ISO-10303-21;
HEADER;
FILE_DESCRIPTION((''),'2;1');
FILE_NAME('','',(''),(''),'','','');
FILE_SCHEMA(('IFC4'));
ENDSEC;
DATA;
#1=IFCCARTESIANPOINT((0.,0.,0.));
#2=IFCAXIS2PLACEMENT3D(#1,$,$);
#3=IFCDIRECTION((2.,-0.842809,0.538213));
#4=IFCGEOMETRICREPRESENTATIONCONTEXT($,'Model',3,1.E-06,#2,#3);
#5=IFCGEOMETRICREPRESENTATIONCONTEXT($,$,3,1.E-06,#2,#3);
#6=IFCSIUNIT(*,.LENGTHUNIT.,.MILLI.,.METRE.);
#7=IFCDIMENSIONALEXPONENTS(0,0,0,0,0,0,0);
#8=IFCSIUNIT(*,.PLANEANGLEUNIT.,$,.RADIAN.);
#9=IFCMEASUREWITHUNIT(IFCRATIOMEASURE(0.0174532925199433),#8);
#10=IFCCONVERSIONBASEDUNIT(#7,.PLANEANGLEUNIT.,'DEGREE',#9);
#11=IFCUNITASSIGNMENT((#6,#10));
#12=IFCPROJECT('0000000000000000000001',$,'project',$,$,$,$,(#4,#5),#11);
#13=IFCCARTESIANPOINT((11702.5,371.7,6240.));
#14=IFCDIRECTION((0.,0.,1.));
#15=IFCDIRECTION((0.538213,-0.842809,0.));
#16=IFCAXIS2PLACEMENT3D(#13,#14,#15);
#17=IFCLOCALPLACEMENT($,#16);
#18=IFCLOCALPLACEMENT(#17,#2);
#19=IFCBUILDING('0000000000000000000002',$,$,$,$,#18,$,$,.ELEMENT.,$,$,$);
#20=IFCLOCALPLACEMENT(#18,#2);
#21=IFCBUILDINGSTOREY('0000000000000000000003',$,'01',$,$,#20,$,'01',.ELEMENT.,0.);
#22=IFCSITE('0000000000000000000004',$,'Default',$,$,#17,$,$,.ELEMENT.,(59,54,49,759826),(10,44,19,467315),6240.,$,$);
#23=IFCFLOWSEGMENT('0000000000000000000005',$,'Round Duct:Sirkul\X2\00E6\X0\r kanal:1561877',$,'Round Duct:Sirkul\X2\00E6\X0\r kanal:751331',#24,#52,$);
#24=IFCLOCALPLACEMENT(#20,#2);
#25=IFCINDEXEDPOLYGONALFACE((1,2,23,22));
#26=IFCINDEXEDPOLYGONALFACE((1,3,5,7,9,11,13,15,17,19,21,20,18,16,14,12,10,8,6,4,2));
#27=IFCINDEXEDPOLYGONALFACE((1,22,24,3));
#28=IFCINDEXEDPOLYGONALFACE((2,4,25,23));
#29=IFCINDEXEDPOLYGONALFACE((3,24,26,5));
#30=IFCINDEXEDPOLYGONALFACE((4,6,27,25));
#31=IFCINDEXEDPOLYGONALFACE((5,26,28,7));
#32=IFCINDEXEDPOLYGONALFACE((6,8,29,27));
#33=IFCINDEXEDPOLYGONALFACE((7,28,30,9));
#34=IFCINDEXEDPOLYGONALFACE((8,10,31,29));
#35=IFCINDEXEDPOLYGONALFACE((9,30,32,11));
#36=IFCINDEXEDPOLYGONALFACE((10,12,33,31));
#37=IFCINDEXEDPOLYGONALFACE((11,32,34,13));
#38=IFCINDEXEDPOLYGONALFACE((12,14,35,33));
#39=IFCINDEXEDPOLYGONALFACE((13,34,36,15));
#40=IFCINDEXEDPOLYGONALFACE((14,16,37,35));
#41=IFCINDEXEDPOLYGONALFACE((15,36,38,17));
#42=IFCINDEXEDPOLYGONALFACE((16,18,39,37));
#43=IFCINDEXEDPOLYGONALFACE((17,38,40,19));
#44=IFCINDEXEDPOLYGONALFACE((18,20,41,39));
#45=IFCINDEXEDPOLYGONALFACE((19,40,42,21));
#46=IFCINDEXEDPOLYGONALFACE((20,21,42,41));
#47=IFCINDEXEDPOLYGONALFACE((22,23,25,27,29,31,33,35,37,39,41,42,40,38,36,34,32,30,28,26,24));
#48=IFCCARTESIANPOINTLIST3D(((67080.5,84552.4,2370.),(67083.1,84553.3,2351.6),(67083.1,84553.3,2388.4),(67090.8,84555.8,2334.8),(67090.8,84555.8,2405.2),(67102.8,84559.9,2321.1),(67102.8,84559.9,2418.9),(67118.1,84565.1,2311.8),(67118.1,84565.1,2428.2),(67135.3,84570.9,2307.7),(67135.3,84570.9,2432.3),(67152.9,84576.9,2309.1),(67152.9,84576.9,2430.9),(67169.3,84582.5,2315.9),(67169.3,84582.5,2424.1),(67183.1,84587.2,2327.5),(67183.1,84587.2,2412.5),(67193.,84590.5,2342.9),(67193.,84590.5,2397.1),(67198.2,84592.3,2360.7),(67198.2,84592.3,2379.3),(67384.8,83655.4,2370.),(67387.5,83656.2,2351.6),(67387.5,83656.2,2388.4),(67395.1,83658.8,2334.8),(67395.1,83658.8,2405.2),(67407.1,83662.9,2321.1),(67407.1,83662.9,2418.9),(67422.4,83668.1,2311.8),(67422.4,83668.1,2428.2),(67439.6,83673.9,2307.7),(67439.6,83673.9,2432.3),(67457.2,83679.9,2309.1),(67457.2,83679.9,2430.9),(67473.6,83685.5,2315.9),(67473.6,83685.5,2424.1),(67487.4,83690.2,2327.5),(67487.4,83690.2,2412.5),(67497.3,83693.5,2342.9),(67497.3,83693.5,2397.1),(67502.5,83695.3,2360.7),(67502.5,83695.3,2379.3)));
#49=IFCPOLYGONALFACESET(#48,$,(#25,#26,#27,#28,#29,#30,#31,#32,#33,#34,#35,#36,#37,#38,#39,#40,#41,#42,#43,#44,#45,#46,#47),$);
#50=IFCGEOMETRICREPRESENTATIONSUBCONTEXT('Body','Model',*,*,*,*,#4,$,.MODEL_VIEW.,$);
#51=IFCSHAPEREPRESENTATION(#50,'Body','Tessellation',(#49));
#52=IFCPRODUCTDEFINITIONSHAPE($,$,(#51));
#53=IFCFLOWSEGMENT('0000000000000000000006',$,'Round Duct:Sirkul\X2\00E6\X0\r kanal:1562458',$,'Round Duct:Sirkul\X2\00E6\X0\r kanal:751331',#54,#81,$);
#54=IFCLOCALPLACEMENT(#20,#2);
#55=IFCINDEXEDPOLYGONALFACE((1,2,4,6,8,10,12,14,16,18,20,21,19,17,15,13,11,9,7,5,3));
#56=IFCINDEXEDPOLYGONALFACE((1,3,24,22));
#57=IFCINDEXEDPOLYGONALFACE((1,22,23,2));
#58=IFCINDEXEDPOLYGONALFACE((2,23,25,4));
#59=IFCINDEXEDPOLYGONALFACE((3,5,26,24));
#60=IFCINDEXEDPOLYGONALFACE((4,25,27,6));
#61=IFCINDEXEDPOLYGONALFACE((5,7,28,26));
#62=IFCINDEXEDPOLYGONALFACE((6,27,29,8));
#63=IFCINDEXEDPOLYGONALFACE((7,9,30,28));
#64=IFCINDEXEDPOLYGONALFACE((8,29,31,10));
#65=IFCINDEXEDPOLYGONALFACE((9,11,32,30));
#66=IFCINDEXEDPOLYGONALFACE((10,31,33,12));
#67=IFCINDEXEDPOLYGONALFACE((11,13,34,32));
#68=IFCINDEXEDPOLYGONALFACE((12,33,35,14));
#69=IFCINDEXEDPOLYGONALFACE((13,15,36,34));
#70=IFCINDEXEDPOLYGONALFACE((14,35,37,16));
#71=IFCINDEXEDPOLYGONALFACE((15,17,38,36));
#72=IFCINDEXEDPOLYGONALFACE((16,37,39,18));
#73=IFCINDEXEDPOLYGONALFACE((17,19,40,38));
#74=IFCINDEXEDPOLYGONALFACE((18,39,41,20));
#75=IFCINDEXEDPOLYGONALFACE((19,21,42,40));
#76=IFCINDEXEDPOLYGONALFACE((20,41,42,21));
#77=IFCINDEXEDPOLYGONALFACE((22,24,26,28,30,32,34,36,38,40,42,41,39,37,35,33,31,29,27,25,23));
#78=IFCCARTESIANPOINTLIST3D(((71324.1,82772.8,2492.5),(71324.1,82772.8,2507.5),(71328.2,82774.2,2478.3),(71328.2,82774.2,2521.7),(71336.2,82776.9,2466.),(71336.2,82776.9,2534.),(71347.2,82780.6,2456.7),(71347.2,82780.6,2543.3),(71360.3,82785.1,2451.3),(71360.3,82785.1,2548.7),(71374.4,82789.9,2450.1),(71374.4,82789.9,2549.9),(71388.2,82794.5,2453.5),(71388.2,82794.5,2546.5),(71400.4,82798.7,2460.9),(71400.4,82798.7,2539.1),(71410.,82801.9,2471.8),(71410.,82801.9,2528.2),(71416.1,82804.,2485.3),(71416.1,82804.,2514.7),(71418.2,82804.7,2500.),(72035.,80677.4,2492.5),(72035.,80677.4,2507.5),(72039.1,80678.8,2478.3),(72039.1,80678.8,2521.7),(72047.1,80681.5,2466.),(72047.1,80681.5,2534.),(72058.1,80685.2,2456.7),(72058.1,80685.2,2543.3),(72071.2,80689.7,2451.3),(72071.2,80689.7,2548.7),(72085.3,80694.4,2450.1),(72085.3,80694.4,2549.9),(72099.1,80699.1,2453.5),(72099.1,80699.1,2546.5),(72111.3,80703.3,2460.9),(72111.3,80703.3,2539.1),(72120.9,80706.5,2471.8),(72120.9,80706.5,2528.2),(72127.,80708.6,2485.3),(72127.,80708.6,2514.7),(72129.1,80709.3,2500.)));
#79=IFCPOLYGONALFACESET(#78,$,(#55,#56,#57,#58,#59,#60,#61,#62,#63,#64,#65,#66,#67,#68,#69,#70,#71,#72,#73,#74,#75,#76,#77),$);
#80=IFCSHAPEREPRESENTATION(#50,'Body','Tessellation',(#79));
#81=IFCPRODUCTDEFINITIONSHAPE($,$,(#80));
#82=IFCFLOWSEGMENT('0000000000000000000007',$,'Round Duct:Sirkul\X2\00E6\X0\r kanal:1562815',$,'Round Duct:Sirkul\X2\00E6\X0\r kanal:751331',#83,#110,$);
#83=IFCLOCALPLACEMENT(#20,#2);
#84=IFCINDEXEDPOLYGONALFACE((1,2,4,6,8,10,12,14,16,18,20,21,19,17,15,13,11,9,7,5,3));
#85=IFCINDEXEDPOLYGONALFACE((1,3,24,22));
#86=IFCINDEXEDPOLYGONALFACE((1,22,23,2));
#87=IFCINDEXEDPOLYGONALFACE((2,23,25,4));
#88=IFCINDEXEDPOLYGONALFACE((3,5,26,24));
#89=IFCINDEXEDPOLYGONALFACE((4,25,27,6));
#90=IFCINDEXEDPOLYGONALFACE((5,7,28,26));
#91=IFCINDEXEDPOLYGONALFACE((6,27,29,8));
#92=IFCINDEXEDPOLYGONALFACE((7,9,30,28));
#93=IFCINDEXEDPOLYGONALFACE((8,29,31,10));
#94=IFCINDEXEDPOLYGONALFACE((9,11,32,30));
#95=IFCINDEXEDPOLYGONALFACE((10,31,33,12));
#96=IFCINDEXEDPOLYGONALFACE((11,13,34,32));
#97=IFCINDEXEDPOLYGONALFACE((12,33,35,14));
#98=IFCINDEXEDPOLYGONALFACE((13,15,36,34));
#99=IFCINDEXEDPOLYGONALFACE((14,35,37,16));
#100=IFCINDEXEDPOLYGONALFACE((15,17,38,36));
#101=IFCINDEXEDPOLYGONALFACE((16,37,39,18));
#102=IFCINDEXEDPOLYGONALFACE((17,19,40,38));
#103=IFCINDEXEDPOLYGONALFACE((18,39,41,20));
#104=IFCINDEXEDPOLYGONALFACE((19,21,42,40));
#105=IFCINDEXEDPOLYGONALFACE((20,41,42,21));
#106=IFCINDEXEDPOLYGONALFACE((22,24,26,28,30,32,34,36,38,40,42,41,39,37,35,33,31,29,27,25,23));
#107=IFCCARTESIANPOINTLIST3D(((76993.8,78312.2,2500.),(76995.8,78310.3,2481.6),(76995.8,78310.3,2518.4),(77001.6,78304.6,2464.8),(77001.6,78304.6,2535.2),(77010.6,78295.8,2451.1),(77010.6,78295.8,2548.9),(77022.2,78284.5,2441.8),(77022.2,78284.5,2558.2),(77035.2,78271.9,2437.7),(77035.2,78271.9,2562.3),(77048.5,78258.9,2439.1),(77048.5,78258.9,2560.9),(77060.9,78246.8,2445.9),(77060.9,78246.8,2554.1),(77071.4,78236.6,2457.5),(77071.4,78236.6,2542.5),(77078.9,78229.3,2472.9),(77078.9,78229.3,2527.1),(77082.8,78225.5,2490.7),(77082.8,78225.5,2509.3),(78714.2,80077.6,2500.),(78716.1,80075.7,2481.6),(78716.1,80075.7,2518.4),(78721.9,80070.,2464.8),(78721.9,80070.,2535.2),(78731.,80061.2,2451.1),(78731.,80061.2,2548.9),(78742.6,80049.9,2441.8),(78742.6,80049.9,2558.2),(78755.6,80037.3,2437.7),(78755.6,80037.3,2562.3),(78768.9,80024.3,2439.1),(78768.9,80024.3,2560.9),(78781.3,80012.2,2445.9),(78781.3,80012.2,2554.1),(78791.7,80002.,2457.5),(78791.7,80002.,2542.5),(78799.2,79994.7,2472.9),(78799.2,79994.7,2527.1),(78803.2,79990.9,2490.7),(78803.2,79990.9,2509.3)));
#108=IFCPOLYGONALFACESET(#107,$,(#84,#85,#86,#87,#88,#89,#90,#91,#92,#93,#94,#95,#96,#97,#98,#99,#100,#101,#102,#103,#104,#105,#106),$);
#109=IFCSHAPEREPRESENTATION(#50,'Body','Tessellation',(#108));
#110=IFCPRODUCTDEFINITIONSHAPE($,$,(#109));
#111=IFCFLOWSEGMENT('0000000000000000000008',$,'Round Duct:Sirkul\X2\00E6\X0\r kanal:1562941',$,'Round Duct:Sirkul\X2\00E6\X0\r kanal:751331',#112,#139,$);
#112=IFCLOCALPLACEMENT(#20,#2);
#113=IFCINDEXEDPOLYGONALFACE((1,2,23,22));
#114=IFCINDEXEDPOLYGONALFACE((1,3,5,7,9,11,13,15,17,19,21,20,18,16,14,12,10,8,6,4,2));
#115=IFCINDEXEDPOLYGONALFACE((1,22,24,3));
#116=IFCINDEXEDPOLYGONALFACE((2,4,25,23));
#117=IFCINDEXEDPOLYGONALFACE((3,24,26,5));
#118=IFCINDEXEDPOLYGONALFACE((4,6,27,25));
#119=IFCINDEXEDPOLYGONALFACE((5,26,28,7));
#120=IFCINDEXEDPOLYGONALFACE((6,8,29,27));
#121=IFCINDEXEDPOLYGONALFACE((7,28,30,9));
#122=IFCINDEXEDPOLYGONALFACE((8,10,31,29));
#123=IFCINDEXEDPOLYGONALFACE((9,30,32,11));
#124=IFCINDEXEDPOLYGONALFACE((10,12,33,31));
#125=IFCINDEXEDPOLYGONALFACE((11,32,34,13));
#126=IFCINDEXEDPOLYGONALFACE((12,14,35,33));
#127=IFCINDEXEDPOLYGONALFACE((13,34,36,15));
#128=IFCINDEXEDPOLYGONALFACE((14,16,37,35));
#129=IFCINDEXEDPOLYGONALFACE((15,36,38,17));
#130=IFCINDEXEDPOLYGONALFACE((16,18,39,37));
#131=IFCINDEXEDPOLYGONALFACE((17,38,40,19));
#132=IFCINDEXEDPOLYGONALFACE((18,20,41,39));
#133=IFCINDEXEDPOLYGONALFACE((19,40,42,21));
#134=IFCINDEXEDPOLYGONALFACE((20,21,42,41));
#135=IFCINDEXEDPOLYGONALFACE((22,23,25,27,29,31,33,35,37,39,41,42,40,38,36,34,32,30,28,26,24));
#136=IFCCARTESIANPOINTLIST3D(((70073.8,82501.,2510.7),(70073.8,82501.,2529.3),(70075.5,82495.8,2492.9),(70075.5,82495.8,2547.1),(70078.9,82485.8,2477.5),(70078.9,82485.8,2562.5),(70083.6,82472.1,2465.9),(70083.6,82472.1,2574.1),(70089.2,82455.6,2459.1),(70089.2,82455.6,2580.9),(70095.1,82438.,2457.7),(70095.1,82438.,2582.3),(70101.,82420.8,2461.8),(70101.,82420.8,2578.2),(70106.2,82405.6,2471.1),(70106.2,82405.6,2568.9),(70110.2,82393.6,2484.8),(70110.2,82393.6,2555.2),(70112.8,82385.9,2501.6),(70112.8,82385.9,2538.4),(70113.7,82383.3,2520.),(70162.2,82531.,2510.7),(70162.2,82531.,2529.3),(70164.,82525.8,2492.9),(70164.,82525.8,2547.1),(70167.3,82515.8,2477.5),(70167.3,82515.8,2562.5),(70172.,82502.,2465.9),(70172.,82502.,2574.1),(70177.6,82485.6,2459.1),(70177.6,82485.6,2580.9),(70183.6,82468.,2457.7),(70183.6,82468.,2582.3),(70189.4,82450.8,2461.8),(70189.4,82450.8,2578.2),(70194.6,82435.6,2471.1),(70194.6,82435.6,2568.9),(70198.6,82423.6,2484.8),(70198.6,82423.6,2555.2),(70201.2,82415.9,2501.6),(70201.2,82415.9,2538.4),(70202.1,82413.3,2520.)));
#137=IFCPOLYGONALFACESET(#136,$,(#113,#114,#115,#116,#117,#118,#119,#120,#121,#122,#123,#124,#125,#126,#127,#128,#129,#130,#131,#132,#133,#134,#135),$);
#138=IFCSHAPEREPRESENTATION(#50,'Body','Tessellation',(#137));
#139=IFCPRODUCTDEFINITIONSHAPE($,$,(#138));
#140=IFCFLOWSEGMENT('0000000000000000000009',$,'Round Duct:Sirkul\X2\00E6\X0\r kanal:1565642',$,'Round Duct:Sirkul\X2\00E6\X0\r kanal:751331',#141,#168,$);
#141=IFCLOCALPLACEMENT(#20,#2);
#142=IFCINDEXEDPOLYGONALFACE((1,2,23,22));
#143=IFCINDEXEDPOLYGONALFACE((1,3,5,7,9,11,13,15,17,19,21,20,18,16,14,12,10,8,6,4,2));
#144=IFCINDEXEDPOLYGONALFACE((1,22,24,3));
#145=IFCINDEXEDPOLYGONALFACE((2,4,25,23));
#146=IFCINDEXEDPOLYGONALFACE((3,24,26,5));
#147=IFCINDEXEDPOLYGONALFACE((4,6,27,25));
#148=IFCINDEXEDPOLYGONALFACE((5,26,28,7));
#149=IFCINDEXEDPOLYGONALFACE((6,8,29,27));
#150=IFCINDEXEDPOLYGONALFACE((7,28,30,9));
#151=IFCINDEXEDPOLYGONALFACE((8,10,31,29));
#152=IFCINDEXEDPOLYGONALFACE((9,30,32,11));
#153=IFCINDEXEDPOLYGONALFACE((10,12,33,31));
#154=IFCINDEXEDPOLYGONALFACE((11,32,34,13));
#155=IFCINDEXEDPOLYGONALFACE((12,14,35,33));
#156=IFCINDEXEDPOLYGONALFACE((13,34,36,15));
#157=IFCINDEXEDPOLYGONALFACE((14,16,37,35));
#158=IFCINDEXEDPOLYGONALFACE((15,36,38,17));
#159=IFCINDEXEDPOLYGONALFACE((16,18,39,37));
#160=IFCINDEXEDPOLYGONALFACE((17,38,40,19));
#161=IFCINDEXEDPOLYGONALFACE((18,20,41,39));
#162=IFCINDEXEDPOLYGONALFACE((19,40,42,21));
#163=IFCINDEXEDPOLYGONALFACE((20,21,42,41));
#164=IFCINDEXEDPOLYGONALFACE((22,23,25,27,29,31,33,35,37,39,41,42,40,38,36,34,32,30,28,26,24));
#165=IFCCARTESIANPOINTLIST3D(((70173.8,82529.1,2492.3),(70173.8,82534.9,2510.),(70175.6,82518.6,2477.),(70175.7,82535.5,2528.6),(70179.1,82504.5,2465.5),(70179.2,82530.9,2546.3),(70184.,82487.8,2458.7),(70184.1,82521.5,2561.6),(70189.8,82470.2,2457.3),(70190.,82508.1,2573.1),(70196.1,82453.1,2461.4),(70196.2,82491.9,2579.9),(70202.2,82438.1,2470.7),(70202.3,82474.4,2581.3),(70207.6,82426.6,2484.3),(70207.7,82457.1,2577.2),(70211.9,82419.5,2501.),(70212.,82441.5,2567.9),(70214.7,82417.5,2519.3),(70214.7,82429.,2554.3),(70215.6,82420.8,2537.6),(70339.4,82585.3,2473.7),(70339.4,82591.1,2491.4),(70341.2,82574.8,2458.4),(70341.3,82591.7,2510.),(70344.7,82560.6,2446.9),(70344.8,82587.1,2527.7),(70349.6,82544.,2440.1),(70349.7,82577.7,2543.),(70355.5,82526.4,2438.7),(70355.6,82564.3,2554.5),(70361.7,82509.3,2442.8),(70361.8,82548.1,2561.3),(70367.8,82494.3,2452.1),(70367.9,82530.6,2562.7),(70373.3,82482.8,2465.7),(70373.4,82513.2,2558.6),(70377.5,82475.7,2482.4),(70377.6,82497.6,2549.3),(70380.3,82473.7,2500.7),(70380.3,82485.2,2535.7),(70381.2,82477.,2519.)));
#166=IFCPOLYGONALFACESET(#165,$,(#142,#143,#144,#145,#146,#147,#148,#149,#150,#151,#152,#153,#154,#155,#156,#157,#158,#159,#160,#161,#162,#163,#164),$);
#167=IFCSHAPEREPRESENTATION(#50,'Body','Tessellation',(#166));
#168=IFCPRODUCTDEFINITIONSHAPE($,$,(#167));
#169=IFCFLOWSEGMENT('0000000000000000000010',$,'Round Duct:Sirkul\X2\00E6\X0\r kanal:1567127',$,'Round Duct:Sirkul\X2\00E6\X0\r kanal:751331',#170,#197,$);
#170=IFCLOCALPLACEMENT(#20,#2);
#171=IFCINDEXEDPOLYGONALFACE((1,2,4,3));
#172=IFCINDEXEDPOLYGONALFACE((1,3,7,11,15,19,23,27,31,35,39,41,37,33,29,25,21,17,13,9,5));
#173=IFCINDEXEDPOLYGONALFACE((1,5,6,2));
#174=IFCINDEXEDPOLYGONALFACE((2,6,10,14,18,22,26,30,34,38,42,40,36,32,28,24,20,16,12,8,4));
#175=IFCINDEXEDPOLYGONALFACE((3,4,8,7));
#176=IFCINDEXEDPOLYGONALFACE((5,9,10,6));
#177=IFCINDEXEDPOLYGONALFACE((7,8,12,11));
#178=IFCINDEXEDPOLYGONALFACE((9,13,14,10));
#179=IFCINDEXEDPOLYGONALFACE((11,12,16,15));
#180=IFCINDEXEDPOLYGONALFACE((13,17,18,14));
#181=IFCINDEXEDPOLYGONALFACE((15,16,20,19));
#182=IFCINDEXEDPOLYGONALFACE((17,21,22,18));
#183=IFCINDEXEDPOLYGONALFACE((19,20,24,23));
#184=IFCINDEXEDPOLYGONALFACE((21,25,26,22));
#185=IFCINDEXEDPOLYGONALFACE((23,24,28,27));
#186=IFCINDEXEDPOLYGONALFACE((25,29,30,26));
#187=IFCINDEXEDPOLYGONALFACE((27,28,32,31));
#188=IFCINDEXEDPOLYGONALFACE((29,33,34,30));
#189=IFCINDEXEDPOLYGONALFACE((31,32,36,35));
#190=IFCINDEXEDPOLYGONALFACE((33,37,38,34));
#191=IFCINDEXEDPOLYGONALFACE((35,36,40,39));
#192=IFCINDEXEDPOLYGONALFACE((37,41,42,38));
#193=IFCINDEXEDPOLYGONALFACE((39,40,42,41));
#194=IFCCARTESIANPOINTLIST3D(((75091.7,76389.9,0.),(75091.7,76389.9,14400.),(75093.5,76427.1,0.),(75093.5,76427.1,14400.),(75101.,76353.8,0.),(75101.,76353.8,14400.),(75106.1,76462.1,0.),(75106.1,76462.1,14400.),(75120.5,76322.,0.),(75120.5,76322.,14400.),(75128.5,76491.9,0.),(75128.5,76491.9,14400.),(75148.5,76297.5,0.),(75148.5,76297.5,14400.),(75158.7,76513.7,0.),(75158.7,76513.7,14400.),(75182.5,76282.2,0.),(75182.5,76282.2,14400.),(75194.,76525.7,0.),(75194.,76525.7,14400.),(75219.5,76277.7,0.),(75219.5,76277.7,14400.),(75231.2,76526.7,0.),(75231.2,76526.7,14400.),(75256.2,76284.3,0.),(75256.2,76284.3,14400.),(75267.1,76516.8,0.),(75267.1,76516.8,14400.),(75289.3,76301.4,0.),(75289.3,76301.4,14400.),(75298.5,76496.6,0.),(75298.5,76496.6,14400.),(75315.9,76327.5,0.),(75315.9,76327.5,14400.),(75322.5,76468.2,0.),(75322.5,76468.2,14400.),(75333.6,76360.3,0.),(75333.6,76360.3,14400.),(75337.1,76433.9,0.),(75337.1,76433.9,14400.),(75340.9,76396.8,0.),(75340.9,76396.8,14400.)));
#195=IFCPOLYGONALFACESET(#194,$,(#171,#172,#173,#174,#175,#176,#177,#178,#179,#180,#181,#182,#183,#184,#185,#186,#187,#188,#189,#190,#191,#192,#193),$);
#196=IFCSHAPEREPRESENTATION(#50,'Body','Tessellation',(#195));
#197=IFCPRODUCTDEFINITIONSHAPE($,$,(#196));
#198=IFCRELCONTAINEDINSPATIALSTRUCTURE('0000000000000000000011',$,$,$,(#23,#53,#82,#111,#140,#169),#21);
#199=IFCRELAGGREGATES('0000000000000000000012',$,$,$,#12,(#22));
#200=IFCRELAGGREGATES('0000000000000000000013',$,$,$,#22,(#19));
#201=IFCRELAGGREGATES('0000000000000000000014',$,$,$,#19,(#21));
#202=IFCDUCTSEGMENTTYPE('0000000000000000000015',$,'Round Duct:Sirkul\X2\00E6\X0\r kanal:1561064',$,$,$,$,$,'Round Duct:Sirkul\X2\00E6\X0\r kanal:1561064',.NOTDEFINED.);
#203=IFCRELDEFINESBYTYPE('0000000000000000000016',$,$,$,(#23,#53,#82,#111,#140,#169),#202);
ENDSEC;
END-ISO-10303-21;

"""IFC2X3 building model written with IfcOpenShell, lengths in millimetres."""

from ifc_helpers import new_model, entity, si_unit, converted_unit, direction, frame, frame_2d, origin, origin_2d_with_axis, place, context, subcontext, project, spatial, circle, extrude, type_object, element, save


model = new_model("IFC2X3")

# Units and contexts
model_context = context("Model", 3, precision=1e-06, world=origin(), true_north=direction((2.0, -0.842809, 0.538213)))
context_of_model = context(None, 3, precision=1e-06, world=origin(), true_north=direction((2.0, -0.842809, 0.538213)))
body_context = subcontext(model_context, "Body", "Model", "MODEL_VIEW")
ifc_project = project(units=[si_unit("LENGTHUNIT", "METRE", prefix="MILLI"), converted_unit("PLANEANGLEUNIT", "DEGREE", entity("IfcRatioMeasure", 0.0174532925199433), si_unit("PLANEANGLEUNIT", "RADIAN"), dimensions=[0, 0, 0, 0, 0, 0, 0])], contexts=[model_context, context_of_model])

# Site, building, storey
site_placement = place(None, frame((11702.5, 371.7, 6240.0), z_axis=(0.0, 0.0, 1.0), x_axis=(0.538213, -0.842809, 0.0)))
site = spatial("IfcSite", under=ifc_project, at=site_placement, Name="Default", CompositionType="ELEMENT", RefLatitude=(59, 54, 49, 759826), RefLongitude=(10, 44, 19, 467315), RefElevation=6240.0)
building_placement = place(site_placement, origin())
building = spatial("IfcBuilding", under=site, at=building_placement, CompositionType="ELEMENT")
storey_placement = place(building_placement, origin())
storey = spatial("IfcBuildingStorey", under=building, at=storey_placement, Name="01", LongName="01", CompositionType="ELEMENT", Elevation=0.0)

# Flow segments
duct_segment_type = type_object("IfcDuctSegmentType", Name="Round Duct:Sirkulær kanal:1561064", ElementType="Round Duct:Sirkulær kanal:1561064", PredefinedType="NOTDEFINED")
flow_segment_1_placement = place(storey_placement, origin())
element("IfcFlowSegment", 1, at=flow_segment_1_placement, inside=storey, type_object=duct_segment_type, Name="Round Duct:Sirkulær kanal:1561877", ObjectType="Round Duct:Sirkulær kanal:751331", context=body_context, shape_type="SweptSolid", body=[
    extrude(circle(Radius=62.5, at=frame_2d((0.0, 0.0), x_axis=(1.0, 0.0))), frame((67444.0, 83675.4, 2370.0), z_axis=(-0.321267, 0.946988, 0.0), x_axis=(-0.946988, -0.321267, 0.0)), (0.0, 0.0, 1.0), 947.2),
])
flow_segment_2_placement = place(storey_placement, origin())
element("IfcFlowSegment", 2, at=flow_segment_2_placement, inside=storey, type_object=duct_segment_type, Name="Round Duct:Sirkulær kanal:1562458", ObjectType="Round Duct:Sirkulær kanal:751331", context=body_context, shape_type="SweptSolid", body=[
    extrude(circle(Radius=50.0, at=origin_2d_with_axis()), frame((71370.9, 82788.7, 2500.0), z_axis=(0.321274, -0.946986, 0.0), x_axis=(0.946986, 0.321274, 0.0)), (0.0, 0.0, 1.0), 2212.7),
])
flow_segment_3_placement = place(storey_placement, origin())
element("IfcFlowSegment", 3, at=flow_segment_3_placement, inside=storey, type_object=duct_segment_type, Name="Round Duct:Sirkulær kanal:1562815", ObjectType="Round Duct:Sirkulær kanal:751331", context=body_context, shape_type="SweptSolid", body=[
    extrude(circle(Radius=62.5, at=frame_2d((0.0, 0.0), x_axis=(1.0, 0.0))), frame((77038.5, 78268.6, 2500.0), z_axis=(0.697915, 0.71618, 0.0), x_axis=(-0.71618, 0.697915, 0.0)), (0.0, 0.0, 1.0), 2465.0),
])
flow_segment_4_placement = place(storey_placement, origin())
element("IfcFlowSegment", 4, at=flow_segment_4_placement, inside=storey, type_object=duct_segment_type, Name="Round Duct:Sirkulær kanal:1562941", ObjectType="Round Duct:Sirkulær kanal:751331", context=body_context, shape_type="SweptSolid", body=[
    extrude(circle(Radius=62.5, at=origin_2d_with_axis()), frame((70093.6, 82442.5, 2520.0), z_axis=(0.946986, 0.321274, 0.0), x_axis=(0.321274, -0.946986, 0.0)), (0.0, 0.0, 1.0), 93.4),
])
flow_segment_5_placement = place(storey_placement, origin())
element("IfcFlowSegment", 5, at=flow_segment_5_placement, inside=storey, type_object=duct_segment_type, Name="Round Duct:Sirkulær kanal:1565642", ObjectType="Round Duct:Sirkulær kanal:751331", context=body_context, shape_type="SweptSolid", body=[
    extrude(circle(Radius=62.5, at=frame_2d((0.0, 0.0), x_axis=(1.0, 0.0))), frame((70360.2, 82532.9, 2500.7), z_axis=(-0.941677, -0.319473, 0.105746), x_axis=(0.321274, -0.946986, 0.0)), (0.0, 0.0, 1.0), 175.9),
])
flow_segment_6_placement = place(storey_placement, origin())
element("IfcFlowSegment", 6, at=flow_segment_6_placement, inside=storey, type_object=duct_segment_type, Name="Round Duct:Sirkulær kanal:1567127", ObjectType="Round Duct:Sirkulær kanal:751331", context=body_context, shape_type="SweptSolid", body=[
    extrude(circle(Radius=125.0, at=origin_2d_with_axis()), frame((75216.0, 76402.7, 0.0), z_axis=(0.0, 0.0, 1.0), x_axis=(0.321274, -0.946986, 0.0)), (0.0, 0.0, 1.0), 14400.0),
])

save(model, "model.ifc")
